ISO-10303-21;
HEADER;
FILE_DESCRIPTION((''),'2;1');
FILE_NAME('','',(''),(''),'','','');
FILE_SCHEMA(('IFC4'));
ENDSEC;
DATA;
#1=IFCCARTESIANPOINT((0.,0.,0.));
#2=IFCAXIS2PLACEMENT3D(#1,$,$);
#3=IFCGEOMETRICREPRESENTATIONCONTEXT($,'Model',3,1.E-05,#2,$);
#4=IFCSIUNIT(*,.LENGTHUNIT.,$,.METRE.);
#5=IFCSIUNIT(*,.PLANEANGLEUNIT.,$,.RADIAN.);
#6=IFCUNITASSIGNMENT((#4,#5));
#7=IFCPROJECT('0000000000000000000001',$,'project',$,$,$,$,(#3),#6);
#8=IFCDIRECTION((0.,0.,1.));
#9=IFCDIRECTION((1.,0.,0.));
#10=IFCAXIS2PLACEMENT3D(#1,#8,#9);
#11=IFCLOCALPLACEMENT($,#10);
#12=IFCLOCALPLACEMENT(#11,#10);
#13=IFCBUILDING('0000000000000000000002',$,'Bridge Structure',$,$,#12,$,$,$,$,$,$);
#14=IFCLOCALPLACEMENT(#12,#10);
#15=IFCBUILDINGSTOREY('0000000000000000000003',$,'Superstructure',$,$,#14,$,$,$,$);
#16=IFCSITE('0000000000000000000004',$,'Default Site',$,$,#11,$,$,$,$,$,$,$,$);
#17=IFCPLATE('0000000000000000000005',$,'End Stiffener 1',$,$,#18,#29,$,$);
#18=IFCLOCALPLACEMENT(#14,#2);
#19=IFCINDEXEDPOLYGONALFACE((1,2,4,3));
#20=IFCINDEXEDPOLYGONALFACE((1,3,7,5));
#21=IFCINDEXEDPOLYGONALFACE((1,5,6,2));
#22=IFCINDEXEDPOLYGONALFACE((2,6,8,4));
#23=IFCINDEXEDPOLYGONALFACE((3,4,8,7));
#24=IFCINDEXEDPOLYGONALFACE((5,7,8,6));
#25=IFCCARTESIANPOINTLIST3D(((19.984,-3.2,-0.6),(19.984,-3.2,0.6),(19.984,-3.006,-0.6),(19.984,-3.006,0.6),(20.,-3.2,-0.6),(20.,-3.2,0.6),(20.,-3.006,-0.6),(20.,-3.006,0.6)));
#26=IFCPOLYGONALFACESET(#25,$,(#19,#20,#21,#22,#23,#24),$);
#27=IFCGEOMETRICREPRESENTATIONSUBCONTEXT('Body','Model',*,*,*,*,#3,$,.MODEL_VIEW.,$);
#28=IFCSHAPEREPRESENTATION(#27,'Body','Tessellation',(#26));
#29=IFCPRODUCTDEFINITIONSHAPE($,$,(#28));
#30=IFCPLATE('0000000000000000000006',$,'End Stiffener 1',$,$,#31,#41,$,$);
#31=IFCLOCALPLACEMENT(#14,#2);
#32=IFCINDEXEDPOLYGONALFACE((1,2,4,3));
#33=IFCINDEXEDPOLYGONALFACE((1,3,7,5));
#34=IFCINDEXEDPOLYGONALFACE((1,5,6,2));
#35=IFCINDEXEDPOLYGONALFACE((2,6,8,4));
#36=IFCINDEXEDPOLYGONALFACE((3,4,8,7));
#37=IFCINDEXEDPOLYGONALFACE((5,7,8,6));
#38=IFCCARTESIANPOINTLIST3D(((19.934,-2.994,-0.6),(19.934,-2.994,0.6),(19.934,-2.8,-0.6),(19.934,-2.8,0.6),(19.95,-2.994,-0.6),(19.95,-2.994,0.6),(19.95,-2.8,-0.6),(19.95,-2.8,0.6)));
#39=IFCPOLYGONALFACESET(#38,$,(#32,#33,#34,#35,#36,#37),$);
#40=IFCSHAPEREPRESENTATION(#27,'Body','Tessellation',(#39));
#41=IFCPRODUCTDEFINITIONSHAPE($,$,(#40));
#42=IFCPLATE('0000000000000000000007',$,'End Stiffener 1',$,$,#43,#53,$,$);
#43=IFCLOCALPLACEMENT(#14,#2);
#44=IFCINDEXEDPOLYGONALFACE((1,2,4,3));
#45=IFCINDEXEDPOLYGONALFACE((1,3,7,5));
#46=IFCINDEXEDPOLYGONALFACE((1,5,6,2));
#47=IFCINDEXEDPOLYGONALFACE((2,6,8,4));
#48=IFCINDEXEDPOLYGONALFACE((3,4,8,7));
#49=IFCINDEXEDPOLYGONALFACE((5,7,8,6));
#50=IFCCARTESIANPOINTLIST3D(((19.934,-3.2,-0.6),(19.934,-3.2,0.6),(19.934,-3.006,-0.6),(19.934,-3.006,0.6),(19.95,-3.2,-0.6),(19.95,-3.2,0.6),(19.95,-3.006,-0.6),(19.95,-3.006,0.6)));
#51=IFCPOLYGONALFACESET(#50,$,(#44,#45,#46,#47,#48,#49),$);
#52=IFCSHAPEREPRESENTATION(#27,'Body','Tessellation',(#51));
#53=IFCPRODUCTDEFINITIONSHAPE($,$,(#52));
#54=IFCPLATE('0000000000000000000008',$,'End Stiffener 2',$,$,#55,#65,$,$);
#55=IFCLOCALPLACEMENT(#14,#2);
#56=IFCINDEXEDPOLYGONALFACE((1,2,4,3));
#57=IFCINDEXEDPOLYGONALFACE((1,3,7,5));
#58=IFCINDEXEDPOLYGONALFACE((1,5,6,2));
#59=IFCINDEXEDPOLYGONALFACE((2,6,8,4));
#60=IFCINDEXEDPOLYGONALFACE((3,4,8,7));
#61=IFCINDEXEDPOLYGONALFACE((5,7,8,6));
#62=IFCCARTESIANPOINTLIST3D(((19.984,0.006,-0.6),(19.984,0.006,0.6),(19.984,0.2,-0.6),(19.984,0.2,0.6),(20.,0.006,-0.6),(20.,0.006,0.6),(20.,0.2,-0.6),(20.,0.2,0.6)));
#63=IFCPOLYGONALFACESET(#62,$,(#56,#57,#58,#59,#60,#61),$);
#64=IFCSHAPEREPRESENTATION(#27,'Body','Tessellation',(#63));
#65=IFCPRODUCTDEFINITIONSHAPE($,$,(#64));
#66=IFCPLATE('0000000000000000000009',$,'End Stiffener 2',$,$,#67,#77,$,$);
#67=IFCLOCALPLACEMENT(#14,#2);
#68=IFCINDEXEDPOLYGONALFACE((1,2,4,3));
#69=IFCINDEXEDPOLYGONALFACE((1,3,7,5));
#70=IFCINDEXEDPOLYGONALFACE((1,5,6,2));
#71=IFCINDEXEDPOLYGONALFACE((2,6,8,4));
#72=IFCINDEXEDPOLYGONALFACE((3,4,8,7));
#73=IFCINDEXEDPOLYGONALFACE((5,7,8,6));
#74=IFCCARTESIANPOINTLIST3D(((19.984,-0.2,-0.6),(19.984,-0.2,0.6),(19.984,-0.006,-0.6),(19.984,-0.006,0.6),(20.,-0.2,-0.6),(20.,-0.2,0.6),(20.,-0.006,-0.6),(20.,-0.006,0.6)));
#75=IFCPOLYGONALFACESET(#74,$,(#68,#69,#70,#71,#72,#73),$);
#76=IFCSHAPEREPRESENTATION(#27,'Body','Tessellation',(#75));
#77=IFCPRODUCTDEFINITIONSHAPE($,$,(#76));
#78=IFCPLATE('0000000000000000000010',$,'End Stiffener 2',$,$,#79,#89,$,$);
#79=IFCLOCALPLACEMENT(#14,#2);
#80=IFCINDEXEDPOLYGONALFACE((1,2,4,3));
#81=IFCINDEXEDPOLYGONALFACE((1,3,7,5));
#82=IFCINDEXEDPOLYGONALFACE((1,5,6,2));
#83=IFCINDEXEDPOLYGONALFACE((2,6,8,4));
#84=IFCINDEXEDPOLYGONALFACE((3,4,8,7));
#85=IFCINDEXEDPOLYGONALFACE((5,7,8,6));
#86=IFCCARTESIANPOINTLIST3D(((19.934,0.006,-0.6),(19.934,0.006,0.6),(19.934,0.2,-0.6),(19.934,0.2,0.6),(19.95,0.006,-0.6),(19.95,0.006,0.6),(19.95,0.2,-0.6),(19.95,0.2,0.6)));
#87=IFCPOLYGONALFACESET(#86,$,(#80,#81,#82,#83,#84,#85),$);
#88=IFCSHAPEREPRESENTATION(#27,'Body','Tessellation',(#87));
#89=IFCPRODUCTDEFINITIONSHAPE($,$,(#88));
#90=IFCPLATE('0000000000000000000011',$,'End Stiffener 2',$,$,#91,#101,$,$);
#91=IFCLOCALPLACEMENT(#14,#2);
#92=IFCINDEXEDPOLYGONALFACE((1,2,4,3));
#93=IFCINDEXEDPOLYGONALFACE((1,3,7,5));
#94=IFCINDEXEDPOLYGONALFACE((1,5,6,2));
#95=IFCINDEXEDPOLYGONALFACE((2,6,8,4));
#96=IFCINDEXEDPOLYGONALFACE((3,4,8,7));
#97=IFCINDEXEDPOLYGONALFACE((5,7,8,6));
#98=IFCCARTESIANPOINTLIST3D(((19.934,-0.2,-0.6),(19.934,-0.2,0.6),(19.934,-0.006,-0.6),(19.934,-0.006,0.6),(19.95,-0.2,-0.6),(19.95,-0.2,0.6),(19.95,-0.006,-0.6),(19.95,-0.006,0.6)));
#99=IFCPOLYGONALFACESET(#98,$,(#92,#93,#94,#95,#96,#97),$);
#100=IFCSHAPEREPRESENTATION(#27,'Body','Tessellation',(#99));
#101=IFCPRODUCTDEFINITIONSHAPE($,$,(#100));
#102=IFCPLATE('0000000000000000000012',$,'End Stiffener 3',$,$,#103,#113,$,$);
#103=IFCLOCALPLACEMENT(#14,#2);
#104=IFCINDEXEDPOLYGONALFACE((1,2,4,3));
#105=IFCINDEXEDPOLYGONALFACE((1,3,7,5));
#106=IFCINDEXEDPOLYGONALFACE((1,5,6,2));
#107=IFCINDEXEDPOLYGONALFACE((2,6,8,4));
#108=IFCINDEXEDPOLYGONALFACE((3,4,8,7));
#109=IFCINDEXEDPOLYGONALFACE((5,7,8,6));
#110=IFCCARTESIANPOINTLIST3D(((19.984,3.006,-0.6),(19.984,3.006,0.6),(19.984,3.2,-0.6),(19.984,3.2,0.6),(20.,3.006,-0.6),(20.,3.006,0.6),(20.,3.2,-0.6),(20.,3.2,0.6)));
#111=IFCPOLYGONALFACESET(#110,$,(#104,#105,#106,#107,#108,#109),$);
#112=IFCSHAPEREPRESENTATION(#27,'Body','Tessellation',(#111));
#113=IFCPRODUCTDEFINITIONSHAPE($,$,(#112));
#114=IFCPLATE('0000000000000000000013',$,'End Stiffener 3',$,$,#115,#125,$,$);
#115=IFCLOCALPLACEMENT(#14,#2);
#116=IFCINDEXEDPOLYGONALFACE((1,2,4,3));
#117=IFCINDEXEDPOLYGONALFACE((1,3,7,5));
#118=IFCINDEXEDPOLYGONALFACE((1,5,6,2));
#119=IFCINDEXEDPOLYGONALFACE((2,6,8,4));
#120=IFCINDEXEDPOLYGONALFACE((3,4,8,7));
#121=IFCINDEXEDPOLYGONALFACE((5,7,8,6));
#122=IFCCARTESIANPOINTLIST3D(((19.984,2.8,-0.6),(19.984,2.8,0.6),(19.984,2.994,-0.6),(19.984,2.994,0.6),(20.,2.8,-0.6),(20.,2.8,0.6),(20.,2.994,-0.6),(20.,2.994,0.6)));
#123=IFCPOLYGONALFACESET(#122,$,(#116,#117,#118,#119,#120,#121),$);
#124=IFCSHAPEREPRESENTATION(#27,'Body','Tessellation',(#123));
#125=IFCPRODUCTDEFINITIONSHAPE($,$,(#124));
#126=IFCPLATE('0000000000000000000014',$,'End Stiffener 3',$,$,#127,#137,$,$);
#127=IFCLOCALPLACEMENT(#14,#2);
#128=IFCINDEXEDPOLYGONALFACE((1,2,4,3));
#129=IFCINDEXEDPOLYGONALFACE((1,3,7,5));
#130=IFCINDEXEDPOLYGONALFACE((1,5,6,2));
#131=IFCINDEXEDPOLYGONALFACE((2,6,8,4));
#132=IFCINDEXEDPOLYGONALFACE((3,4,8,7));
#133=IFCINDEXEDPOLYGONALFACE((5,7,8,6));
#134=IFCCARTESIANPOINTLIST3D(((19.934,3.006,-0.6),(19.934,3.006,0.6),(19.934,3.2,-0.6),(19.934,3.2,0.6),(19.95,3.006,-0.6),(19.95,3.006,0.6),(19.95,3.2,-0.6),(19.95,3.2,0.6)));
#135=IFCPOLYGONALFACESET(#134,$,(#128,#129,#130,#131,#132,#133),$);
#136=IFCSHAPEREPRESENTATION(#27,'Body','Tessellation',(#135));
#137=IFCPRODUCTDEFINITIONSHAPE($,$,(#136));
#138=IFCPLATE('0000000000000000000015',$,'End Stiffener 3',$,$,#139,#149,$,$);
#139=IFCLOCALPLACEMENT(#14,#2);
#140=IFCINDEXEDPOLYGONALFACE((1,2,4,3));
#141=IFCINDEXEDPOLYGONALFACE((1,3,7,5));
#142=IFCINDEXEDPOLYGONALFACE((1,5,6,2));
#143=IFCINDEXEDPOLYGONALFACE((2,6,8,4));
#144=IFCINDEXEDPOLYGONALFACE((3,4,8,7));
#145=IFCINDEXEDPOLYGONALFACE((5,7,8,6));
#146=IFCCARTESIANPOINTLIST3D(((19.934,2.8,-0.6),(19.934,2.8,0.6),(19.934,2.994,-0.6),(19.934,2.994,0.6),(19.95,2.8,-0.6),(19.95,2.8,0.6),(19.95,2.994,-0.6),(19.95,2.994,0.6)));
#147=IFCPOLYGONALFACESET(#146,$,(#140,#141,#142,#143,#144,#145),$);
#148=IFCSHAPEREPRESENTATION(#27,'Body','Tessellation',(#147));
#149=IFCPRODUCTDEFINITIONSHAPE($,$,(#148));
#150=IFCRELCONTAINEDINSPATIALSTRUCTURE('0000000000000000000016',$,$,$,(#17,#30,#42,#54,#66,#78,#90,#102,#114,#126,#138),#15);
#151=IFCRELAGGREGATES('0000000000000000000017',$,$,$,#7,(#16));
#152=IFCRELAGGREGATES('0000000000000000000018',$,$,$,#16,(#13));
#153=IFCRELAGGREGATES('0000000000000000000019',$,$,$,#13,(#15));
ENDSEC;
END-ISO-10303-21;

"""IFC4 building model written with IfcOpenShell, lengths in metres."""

from ifc_helpers import new_model, si_unit, frame, origin, origin_with_axes, origin_2d_with_axis, place, context, subcontext, project, spatial, rectangle, extrude, element, save


model = new_model("IFC4")

# Units and contexts
model_context = context("Model", 3, precision=1e-05, world=origin())
body_context = subcontext(model_context, "Body", "Model", "MODEL_VIEW")
ifc_project = project(units=[si_unit("LENGTHUNIT", "METRE"), si_unit("PLANEANGLEUNIT", "RADIAN")], contexts=[model_context])

# Site, building, storey
site_placement = place(None, origin_with_axes())
site = spatial("IfcSite", under=ifc_project, at=site_placement, Name="Default Site")
building_placement = place(site_placement, origin_with_axes())
building = spatial("IfcBuilding", under=site, at=building_placement, Name="Bridge Structure")
storey_placement = place(building_placement, origin_with_axes())
storey = spatial("IfcBuildingStorey", under=building, at=storey_placement, Name="Superstructure")

# Plates
for number, where, z_axis, x_axis, name in (
    (1, (19.992, -3.103, -0.6), (0.0, 0.0, 1.0), (1.0, 0.0, 0.0), "End Stiffener 1"),
    (2, (19.942, -2.897, -0.6), (0.0, 0.0, 1.0), (1.0, 0.0, 0.0), "End Stiffener 1"),
    (3, (19.942, -3.103, -0.6), (0.0, 0.0, 1.0), (1.0, 0.0, 0.0), "End Stiffener 1"),
    (4, (19.992, 0.103, -0.6), (0.0, 0.0, 1.0), (1.0, 0.0, 0.0), "End Stiffener 2"),
    (5, (19.992, -0.103, -0.6), (0.0, 0.0, 1.0), (1.0, 0.0, 0.0), "End Stiffener 2"),
    (6, (19.942, 0.103, -0.6), (0.0, 0.0, 1.0), (1.0, 0.0, 0.0), "End Stiffener 2"),
    (7, (19.942, -0.103, -0.6), (0.0, 0.0, 1.0), (1.0, 0.0, 0.0), "End Stiffener 2"),
    (8, (19.992, 3.103, -0.6), (0.0, 0.0, 1.0), (1.0, 0.0, 0.0), "End Stiffener 3"),
    (9, (19.992, 2.897, -0.6), (0.0, 0.0, 1.0), (1.0, 0.0, 0.0), "End Stiffener 3"),
    (10, (19.942, 3.103, -0.6), (0.0, 0.0, 1.0), (1.0, 0.0, 0.0), "End Stiffener 3"),
    (11, (19.942, 2.897, -0.6), (0.0, 0.0, 1.0), (1.0, 0.0, 0.0), "End Stiffener 3"),
):
    element("IfcPlate", number, at=place(storey_placement, frame(where, z_axis=z_axis, x_axis=x_axis)), inside=storey, Name=name, context=body_context, shape_type="SweptSolid", body=[
        extrude(rectangle(XDim=0.016, YDim=0.194, at=origin_2d_with_axis()), origin_with_axes(), (0.0, 0.0, 1.0), 1.2),
    ])

save(model, "model.ifc")
